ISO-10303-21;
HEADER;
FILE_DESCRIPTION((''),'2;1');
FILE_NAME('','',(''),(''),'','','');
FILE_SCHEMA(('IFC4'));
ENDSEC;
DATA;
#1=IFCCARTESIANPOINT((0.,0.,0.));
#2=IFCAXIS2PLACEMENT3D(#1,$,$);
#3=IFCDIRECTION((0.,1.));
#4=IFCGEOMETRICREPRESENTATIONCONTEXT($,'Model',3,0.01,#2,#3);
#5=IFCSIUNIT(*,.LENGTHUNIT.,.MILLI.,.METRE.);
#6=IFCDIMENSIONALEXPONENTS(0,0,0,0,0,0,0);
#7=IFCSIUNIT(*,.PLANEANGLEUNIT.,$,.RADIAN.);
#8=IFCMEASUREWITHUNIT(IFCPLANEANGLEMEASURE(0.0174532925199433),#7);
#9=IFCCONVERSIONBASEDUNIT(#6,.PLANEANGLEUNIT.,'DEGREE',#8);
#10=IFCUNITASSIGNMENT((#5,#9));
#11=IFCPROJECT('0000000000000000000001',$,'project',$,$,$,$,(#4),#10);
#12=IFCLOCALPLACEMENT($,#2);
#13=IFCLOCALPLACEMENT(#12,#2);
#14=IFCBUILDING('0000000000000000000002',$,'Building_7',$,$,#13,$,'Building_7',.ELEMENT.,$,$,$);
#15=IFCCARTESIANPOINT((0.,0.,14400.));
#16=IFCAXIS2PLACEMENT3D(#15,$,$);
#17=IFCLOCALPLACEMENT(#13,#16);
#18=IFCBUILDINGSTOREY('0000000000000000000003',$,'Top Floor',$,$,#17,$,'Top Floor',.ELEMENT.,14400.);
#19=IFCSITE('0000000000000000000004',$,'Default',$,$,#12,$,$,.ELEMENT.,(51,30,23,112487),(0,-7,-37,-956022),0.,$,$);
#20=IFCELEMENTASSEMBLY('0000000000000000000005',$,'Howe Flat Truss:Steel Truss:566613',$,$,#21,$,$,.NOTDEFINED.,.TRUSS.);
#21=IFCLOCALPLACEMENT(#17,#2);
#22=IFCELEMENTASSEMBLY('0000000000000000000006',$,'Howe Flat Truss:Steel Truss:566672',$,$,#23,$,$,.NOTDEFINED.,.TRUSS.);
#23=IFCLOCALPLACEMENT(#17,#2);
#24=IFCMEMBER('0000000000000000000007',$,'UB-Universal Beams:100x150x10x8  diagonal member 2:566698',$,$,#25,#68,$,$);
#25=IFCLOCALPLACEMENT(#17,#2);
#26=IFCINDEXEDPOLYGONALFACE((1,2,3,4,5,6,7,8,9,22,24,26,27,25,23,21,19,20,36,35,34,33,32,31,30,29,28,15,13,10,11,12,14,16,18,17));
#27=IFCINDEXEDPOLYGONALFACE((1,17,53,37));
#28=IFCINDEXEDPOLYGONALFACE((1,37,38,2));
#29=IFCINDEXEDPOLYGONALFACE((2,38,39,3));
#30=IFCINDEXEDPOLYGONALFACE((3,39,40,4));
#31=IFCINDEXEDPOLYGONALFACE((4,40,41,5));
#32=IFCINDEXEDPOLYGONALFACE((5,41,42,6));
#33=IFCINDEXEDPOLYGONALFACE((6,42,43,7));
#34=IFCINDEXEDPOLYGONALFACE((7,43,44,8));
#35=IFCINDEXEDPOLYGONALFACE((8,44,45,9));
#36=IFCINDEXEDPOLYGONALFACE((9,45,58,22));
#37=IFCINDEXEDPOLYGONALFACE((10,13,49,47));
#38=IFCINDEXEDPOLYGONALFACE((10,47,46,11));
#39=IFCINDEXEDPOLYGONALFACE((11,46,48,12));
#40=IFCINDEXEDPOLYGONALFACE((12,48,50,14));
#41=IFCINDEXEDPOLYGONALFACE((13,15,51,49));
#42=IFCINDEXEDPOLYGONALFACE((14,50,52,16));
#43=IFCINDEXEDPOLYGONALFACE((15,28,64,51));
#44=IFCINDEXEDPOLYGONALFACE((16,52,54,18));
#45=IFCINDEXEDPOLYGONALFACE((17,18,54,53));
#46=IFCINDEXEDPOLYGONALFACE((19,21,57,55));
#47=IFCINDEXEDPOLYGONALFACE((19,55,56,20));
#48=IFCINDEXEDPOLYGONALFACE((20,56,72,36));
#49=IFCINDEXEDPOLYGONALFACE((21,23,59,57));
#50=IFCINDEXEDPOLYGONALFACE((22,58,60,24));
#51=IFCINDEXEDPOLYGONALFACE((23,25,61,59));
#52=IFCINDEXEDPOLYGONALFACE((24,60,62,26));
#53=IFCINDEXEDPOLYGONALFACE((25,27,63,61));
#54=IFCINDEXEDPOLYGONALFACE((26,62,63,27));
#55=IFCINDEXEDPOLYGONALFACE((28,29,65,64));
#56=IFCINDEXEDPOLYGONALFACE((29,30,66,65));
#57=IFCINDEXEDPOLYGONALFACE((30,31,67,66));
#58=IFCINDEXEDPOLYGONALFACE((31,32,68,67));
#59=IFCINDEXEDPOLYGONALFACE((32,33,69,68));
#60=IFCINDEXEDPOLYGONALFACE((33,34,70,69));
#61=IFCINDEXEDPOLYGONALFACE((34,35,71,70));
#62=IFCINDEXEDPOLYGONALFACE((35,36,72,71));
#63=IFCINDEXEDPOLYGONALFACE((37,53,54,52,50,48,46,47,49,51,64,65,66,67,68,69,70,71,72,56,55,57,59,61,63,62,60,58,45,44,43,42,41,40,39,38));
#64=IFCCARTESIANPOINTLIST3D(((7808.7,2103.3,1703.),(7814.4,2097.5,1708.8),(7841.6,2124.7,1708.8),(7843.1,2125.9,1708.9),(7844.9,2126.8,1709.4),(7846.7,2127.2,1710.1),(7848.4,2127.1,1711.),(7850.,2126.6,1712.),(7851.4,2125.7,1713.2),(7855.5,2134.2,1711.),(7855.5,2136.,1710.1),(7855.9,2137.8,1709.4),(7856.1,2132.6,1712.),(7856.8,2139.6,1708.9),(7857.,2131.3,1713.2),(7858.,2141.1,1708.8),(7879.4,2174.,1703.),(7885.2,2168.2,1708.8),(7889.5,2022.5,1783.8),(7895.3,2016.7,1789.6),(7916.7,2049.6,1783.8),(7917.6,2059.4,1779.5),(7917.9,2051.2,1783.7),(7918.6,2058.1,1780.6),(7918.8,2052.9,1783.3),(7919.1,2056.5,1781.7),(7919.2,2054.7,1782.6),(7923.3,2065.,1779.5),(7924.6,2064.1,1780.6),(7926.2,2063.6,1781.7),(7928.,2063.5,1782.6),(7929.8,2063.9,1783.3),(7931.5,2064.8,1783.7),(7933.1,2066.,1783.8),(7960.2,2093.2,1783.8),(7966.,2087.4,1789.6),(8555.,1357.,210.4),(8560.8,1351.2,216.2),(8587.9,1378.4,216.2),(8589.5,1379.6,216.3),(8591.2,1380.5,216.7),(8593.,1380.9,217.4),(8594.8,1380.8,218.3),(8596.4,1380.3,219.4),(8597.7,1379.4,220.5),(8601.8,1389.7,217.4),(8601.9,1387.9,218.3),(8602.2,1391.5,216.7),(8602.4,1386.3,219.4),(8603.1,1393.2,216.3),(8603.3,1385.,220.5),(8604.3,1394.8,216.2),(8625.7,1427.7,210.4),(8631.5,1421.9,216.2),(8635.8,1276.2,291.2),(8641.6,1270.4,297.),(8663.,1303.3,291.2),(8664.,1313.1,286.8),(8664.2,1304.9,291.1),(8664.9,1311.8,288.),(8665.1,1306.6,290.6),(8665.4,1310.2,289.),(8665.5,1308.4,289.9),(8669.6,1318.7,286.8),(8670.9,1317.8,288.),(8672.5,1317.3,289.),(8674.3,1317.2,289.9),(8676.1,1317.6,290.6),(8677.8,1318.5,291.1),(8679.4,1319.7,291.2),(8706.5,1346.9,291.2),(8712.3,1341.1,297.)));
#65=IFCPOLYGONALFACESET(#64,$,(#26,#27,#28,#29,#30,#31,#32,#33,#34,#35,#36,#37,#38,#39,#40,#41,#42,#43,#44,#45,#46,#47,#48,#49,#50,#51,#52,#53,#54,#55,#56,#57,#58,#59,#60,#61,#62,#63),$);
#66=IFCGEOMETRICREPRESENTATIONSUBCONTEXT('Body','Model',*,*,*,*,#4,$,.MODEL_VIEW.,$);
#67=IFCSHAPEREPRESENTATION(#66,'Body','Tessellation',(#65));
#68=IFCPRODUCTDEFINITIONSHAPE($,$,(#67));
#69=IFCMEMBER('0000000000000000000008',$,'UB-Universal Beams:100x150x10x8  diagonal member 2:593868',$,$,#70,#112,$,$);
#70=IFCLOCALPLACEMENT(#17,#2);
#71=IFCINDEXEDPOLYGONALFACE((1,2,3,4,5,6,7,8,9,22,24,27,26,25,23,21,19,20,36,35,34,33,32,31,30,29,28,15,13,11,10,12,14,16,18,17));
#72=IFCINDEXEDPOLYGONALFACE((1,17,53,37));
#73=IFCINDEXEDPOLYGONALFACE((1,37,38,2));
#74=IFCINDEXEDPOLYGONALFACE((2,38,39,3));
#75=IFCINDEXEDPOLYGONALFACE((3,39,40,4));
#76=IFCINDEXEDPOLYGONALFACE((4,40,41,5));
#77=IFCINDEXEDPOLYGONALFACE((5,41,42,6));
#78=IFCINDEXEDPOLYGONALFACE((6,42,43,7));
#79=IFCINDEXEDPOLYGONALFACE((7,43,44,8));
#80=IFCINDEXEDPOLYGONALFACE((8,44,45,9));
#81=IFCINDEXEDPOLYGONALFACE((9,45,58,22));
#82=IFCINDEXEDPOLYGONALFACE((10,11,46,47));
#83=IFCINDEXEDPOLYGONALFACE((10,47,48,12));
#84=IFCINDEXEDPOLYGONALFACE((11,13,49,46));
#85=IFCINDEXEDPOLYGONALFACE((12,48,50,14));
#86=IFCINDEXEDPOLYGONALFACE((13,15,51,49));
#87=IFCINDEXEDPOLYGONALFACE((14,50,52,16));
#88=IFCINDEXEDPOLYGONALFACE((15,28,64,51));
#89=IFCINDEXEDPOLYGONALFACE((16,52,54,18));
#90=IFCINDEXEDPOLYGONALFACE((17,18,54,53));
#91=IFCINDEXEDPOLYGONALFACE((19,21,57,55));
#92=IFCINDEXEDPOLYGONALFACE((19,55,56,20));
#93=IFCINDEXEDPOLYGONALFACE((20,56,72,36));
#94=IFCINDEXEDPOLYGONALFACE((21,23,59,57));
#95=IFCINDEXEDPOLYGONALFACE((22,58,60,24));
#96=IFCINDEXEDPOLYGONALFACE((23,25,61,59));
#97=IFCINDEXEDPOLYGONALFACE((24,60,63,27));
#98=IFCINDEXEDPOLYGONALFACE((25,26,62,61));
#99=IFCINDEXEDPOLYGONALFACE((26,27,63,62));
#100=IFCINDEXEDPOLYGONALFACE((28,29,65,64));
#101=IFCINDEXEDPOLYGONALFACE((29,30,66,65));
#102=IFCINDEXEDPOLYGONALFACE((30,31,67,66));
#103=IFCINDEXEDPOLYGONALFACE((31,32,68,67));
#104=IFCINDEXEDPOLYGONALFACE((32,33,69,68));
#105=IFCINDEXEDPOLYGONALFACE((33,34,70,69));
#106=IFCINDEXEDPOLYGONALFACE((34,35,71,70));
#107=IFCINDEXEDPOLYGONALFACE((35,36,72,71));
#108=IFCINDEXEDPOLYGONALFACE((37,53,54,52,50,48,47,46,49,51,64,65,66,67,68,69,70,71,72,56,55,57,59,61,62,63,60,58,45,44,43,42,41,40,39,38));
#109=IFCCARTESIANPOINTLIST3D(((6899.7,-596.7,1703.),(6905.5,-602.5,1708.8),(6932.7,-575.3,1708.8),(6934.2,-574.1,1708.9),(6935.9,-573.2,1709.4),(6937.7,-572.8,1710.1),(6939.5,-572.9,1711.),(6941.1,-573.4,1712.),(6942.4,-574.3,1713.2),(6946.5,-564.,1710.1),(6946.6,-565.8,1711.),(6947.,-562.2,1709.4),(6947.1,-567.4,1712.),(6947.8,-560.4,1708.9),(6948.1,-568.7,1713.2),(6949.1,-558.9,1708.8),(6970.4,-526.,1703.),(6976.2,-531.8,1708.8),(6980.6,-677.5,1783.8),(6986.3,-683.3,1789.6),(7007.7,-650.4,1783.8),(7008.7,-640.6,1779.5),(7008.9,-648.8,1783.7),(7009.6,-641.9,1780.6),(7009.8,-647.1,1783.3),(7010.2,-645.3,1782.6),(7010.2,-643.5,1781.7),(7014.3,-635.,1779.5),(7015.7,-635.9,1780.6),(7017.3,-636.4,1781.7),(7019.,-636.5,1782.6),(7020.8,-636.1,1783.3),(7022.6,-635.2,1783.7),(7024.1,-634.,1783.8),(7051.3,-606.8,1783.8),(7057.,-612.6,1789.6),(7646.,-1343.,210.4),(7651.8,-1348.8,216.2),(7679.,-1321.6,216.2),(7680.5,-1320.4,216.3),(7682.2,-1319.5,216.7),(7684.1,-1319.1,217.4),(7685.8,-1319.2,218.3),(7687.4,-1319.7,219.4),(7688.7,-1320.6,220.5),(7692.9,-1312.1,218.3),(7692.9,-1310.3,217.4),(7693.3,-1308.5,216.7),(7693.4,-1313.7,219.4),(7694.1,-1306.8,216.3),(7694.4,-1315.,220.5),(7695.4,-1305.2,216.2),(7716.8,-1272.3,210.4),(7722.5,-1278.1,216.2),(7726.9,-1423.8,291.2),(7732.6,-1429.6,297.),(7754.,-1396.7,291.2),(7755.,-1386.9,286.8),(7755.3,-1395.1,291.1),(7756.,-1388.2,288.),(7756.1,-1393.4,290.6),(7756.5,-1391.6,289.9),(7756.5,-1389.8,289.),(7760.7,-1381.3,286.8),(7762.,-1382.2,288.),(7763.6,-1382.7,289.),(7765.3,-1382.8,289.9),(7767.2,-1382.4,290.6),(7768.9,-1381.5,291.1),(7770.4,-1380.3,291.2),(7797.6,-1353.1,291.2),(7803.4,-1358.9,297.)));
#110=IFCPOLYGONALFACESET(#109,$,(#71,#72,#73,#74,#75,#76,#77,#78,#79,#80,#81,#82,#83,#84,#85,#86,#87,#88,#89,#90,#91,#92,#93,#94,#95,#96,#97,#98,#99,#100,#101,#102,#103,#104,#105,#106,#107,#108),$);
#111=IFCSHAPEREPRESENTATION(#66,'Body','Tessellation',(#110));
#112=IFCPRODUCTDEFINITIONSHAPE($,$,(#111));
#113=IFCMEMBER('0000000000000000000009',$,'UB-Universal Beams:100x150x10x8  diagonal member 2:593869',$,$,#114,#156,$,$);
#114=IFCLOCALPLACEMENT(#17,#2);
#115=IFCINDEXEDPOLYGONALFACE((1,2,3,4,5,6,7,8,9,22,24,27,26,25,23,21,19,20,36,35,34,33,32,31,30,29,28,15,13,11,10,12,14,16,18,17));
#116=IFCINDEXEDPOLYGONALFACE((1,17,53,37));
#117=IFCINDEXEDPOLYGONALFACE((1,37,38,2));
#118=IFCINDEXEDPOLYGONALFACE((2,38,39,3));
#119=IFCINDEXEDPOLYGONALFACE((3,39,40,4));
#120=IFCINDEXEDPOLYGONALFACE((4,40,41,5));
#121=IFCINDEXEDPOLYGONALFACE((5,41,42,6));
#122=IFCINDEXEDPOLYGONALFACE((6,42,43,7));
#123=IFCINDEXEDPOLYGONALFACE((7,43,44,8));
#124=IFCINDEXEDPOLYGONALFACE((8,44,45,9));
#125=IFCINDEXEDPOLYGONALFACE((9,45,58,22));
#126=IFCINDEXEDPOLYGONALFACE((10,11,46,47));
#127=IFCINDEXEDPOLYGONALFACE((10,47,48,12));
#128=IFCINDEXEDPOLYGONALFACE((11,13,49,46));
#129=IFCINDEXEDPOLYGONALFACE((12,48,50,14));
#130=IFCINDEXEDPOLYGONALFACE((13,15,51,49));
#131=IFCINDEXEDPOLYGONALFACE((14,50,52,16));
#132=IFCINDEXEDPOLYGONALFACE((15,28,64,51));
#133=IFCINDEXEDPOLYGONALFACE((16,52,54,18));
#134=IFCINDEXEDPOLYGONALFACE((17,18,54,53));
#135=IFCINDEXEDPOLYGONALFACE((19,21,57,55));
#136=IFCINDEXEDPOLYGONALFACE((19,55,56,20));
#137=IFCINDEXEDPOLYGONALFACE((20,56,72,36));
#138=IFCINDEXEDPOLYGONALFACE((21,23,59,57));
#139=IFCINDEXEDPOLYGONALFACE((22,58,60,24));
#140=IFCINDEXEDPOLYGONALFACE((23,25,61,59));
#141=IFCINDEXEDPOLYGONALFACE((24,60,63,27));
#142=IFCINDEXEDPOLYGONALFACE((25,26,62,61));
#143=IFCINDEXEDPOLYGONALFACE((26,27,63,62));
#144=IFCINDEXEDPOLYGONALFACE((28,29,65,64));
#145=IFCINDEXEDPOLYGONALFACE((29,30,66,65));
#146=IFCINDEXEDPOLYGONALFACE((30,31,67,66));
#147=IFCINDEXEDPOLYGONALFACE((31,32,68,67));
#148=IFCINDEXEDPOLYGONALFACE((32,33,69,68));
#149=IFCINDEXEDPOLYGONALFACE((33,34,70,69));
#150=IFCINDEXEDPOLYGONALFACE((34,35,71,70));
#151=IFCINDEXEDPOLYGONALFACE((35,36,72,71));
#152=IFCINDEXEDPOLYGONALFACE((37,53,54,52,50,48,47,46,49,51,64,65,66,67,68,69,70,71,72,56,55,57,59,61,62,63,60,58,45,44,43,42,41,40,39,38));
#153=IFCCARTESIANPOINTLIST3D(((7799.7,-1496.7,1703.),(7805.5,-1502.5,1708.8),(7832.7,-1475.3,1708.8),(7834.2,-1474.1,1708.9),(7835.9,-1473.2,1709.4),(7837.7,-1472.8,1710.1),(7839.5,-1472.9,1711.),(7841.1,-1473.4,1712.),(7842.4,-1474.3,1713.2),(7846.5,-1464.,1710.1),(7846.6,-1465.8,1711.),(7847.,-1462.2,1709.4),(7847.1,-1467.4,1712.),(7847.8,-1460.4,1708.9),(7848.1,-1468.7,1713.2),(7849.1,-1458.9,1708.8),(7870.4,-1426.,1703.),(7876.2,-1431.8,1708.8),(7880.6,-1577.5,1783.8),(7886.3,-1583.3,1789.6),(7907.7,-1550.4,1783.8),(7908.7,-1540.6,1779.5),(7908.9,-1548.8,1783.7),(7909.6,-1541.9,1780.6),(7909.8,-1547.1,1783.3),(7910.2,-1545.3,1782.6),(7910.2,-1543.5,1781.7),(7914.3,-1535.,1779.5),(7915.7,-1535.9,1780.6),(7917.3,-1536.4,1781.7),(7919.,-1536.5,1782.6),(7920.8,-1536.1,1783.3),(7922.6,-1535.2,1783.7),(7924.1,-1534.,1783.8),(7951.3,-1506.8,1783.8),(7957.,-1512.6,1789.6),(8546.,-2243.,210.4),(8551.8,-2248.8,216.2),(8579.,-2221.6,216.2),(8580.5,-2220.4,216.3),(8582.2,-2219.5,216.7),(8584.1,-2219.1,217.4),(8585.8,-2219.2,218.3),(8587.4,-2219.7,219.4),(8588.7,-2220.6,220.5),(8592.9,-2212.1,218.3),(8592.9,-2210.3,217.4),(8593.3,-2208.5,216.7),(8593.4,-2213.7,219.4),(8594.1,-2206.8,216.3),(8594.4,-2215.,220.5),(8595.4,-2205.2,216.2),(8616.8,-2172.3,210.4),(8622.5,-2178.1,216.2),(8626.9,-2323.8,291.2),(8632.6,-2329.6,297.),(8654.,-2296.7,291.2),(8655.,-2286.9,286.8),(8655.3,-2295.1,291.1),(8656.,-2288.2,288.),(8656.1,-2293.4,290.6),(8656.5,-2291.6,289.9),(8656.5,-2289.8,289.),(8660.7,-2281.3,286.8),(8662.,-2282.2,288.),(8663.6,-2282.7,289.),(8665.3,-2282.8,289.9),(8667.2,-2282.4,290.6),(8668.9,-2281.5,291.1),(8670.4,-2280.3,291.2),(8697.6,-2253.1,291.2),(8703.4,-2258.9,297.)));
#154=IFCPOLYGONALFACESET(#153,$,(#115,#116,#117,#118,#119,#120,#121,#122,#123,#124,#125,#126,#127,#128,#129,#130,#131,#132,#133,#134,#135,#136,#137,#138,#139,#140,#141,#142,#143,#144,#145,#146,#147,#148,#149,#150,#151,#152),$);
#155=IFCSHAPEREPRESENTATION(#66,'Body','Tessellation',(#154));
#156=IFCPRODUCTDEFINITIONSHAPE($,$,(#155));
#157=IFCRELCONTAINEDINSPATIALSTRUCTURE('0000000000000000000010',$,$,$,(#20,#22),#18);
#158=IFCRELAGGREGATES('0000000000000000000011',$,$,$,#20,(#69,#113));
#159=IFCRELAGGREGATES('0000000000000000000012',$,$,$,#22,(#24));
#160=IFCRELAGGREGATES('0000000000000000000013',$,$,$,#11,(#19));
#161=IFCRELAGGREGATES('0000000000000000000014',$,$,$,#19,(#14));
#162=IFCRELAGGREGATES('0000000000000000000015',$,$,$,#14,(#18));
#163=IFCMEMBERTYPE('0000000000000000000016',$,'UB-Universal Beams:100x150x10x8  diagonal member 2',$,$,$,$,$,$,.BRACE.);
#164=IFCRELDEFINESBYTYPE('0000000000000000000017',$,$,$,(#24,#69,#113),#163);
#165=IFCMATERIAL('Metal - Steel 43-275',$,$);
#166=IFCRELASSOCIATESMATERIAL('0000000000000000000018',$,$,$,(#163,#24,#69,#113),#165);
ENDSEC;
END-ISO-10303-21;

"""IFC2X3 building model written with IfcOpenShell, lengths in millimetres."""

from ifc_helpers import new_model, entity, si_unit, converted_unit, direction, frame, frame_2d, origin, place, context, subcontext, project, spatial, polyline, circle_curve, parameter, trimmed, segment, composite_curve, outline, extrude, source, transform, mapped, material, type_object, type_shapes, element, aggregate, save


model = new_model("IFC2X3")

# Units and contexts
model_context = context("Model", 3, precision=0.01, world=origin(), true_north=direction((0.0, 1.0)))
body_context = subcontext(model_context, "Body", "Model", "MODEL_VIEW")
ifc_project = project(units=[si_unit("LENGTHUNIT", "METRE", prefix="MILLI"), converted_unit("PLANEANGLEUNIT", "DEGREE", entity("IfcPlaneAngleMeasure", 0.0174532925199433), si_unit("PLANEANGLEUNIT", "RADIAN"), dimensions=[0, 0, 0, 0, 0, 0, 0])], contexts=[model_context])

# Site, building, storey
site_placement = place(None, origin())
site = spatial("IfcSite", under=ifc_project, at=site_placement, Name="Default", CompositionType="ELEMENT", RefLatitude=(51, 30, 23, 112487), RefLongitude=(0, -7, -37, -956022), RefElevation=0.0)
building_placement = place(site_placement, origin())
building = spatial("IfcBuilding", under=site, at=building_placement, Name="Building_7", LongName="Building_7", CompositionType="ELEMENT")
storey_placement = place(building_placement, frame((0.0, 0.0, 14400.0)))
storey = spatial("IfcBuildingStorey", under=building, at=storey_placement, Name="Top Floor", LongName="Top Floor", CompositionType="ELEMENT", Elevation=14400.0)

# Shared definitions
ifc_material = material(Name="Metal - Steel 43-275")

# Element assemblies
assembly_1_placement = place(storey_placement, origin())
assembly_1 = element("IfcElementAssembly", 1, at=assembly_1_placement, inside=storey, Name="Howe Flat Truss:Steel Truss:566613", AssemblyPlace="NOTDEFINED", PredefinedType="TRUSS")
assembly_2_placement = place(storey_placement, origin())
assembly_2 = element("IfcElementAssembly", 2, at=assembly_2_placement, inside=storey, Name="Howe Flat Truss:Steel Truss:566672", AssemblyPlace="NOTDEFINED", PredefinedType="TRUSS")

# Members
member_type_1 = type_object("IfcMemberType", Name="UB-Universal Beams:100x150x10x8  diagonal member 2", PredefinedType="BRACE", material=ifc_material)
shared_shape_1 = source(origin(), body_context, "Body", "SweptSolid", [
    extrude(outline(composite_curve([segment(polyline([(-50.0, -65.0), (-50.0, -75.0)]), True, "CONTINUOUS"), segment(polyline([(-50.0, -75.0), (50.0, -75.0)]), True, "CONTINUOUS"), segment(polyline([(50.0, -75.0), (50.0, -65.0)]), True, "CONTINUOUS"), segment(polyline([(50.0, -65.0), (11.6, -65.0)]), True, "CONTINUOUS"), segment(trimmed(circle_curve(frame_2d((11.6, -57.4), x_axis=(1.0, 0.0)), 7.6), [parameter(180.0)], [parameter(270.0)], True, "PARAMETER"), False, "CONTINUOUS"), segment(polyline([(4.0, -57.4), (4.0, 57.4)]), True, "CONTINUOUS"), segment(trimmed(circle_curve(frame_2d((11.6, 57.4), x_axis=(1.0, 0.0)), 7.6), [parameter(90.0)], [parameter(180.0)], True, "PARAMETER"), False, "CONTINUOUS"), segment(polyline([(11.6, 65.0), (50.0, 65.0)]), True, "CONTINUOUS"), segment(polyline([(50.0, 65.0), (50.0, 75.0)]), True, "CONTINUOUS"), segment(polyline([(50.0, 75.0), (-50.0, 75.0)]), True, "CONTINUOUS"), segment(polyline([(-50.0, 75.0), (-50.0, 65.0)]), True, "CONTINUOUS"), segment(polyline([(-50.0, 65.0), (-11.6, 65.0)]), True, "CONTINUOUS"), segment(trimmed(circle_curve(frame_2d((-11.6, 57.4), x_axis=(1.0, 0.0)), 7.6), [parameter(360.0)], [parameter(90.0)], True, "PARAMETER"), False, "CONTINUOUS"), segment(polyline([(-4.0, 57.4), (-4.0, -57.4)]), True, "CONTINUOUS"), segment(trimmed(circle_curve(frame_2d((-11.6, -57.4), x_axis=(1.0, 0.0)), 7.6), [parameter(270.0)], [parameter(360.0)], True, "PARAMETER"), False, "CONTINUOUS"), segment(polyline([(-11.6, -65.0), (-50.0, -65.0)]), True, "CONTINUOUS")], self_intersect=False)), frame((-914.0, 0.0, 0.0), z_axis=(-1.0, 0.0, 0.0), x_axis=(0.0, -1.0, 0.0)), (0.0, 0.0, -1.0), 1828.1),
])
type_shapes(member_type_1, [shared_shape_1])
member_1_placement = place(assembly_2_placement, frame((8260.5, 1722.2, 1000.0), z_axis=(-0.57735, 0.57735, -0.57735), x_axis=(-0.408248, 0.408248, 0.816497)))
member_1 = element("IfcMember", 3, at=member_1_placement, type_object=member_type_1, material=ifc_material, Name="UB-Universal Beams:100x150x10x8  diagonal member 2:566698", context=body_context, shape_type="MappedRepresentation", body=[
    mapped(shared_shape_1, transform((0.0, 0.0, 0.0), scale=1.0)),
])
member_2_placement = place(assembly_1_placement, frame((7351.5, -977.8, 1000.0), z_axis=(-0.57735, 0.57735, -0.57735), x_axis=(0.408248, -0.408248, -0.816497)))
member_2 = element("IfcMember", 4, at=member_2_placement, type_object=member_type_1, material=ifc_material, Name="UB-Universal Beams:100x150x10x8  diagonal member 2:593868", context=body_context, shape_type="MappedRepresentation", body=[
    mapped(shared_shape_1, transform((0.0, 0.0, 0.0), scale=1.0)),
])
member_3_placement = place(assembly_1_placement, frame((8251.5, -1877.8, 1000.0), z_axis=(-0.57735, 0.57735, -0.57735), x_axis=(0.408248, -0.408248, -0.816497)))
member_3 = element("IfcMember", 5, at=member_3_placement, type_object=member_type_1, material=ifc_material, Name="UB-Universal Beams:100x150x10x8  diagonal member 2:593869", context=body_context, shape_type="MappedRepresentation", body=[
    mapped(shared_shape_1, transform((0.0, 0.0, 0.0), scale=1.0)),
])
aggregate(assembly_1, [member_2, member_3])
aggregate(assembly_2, [member_1])

save(model, "model.ifc")
